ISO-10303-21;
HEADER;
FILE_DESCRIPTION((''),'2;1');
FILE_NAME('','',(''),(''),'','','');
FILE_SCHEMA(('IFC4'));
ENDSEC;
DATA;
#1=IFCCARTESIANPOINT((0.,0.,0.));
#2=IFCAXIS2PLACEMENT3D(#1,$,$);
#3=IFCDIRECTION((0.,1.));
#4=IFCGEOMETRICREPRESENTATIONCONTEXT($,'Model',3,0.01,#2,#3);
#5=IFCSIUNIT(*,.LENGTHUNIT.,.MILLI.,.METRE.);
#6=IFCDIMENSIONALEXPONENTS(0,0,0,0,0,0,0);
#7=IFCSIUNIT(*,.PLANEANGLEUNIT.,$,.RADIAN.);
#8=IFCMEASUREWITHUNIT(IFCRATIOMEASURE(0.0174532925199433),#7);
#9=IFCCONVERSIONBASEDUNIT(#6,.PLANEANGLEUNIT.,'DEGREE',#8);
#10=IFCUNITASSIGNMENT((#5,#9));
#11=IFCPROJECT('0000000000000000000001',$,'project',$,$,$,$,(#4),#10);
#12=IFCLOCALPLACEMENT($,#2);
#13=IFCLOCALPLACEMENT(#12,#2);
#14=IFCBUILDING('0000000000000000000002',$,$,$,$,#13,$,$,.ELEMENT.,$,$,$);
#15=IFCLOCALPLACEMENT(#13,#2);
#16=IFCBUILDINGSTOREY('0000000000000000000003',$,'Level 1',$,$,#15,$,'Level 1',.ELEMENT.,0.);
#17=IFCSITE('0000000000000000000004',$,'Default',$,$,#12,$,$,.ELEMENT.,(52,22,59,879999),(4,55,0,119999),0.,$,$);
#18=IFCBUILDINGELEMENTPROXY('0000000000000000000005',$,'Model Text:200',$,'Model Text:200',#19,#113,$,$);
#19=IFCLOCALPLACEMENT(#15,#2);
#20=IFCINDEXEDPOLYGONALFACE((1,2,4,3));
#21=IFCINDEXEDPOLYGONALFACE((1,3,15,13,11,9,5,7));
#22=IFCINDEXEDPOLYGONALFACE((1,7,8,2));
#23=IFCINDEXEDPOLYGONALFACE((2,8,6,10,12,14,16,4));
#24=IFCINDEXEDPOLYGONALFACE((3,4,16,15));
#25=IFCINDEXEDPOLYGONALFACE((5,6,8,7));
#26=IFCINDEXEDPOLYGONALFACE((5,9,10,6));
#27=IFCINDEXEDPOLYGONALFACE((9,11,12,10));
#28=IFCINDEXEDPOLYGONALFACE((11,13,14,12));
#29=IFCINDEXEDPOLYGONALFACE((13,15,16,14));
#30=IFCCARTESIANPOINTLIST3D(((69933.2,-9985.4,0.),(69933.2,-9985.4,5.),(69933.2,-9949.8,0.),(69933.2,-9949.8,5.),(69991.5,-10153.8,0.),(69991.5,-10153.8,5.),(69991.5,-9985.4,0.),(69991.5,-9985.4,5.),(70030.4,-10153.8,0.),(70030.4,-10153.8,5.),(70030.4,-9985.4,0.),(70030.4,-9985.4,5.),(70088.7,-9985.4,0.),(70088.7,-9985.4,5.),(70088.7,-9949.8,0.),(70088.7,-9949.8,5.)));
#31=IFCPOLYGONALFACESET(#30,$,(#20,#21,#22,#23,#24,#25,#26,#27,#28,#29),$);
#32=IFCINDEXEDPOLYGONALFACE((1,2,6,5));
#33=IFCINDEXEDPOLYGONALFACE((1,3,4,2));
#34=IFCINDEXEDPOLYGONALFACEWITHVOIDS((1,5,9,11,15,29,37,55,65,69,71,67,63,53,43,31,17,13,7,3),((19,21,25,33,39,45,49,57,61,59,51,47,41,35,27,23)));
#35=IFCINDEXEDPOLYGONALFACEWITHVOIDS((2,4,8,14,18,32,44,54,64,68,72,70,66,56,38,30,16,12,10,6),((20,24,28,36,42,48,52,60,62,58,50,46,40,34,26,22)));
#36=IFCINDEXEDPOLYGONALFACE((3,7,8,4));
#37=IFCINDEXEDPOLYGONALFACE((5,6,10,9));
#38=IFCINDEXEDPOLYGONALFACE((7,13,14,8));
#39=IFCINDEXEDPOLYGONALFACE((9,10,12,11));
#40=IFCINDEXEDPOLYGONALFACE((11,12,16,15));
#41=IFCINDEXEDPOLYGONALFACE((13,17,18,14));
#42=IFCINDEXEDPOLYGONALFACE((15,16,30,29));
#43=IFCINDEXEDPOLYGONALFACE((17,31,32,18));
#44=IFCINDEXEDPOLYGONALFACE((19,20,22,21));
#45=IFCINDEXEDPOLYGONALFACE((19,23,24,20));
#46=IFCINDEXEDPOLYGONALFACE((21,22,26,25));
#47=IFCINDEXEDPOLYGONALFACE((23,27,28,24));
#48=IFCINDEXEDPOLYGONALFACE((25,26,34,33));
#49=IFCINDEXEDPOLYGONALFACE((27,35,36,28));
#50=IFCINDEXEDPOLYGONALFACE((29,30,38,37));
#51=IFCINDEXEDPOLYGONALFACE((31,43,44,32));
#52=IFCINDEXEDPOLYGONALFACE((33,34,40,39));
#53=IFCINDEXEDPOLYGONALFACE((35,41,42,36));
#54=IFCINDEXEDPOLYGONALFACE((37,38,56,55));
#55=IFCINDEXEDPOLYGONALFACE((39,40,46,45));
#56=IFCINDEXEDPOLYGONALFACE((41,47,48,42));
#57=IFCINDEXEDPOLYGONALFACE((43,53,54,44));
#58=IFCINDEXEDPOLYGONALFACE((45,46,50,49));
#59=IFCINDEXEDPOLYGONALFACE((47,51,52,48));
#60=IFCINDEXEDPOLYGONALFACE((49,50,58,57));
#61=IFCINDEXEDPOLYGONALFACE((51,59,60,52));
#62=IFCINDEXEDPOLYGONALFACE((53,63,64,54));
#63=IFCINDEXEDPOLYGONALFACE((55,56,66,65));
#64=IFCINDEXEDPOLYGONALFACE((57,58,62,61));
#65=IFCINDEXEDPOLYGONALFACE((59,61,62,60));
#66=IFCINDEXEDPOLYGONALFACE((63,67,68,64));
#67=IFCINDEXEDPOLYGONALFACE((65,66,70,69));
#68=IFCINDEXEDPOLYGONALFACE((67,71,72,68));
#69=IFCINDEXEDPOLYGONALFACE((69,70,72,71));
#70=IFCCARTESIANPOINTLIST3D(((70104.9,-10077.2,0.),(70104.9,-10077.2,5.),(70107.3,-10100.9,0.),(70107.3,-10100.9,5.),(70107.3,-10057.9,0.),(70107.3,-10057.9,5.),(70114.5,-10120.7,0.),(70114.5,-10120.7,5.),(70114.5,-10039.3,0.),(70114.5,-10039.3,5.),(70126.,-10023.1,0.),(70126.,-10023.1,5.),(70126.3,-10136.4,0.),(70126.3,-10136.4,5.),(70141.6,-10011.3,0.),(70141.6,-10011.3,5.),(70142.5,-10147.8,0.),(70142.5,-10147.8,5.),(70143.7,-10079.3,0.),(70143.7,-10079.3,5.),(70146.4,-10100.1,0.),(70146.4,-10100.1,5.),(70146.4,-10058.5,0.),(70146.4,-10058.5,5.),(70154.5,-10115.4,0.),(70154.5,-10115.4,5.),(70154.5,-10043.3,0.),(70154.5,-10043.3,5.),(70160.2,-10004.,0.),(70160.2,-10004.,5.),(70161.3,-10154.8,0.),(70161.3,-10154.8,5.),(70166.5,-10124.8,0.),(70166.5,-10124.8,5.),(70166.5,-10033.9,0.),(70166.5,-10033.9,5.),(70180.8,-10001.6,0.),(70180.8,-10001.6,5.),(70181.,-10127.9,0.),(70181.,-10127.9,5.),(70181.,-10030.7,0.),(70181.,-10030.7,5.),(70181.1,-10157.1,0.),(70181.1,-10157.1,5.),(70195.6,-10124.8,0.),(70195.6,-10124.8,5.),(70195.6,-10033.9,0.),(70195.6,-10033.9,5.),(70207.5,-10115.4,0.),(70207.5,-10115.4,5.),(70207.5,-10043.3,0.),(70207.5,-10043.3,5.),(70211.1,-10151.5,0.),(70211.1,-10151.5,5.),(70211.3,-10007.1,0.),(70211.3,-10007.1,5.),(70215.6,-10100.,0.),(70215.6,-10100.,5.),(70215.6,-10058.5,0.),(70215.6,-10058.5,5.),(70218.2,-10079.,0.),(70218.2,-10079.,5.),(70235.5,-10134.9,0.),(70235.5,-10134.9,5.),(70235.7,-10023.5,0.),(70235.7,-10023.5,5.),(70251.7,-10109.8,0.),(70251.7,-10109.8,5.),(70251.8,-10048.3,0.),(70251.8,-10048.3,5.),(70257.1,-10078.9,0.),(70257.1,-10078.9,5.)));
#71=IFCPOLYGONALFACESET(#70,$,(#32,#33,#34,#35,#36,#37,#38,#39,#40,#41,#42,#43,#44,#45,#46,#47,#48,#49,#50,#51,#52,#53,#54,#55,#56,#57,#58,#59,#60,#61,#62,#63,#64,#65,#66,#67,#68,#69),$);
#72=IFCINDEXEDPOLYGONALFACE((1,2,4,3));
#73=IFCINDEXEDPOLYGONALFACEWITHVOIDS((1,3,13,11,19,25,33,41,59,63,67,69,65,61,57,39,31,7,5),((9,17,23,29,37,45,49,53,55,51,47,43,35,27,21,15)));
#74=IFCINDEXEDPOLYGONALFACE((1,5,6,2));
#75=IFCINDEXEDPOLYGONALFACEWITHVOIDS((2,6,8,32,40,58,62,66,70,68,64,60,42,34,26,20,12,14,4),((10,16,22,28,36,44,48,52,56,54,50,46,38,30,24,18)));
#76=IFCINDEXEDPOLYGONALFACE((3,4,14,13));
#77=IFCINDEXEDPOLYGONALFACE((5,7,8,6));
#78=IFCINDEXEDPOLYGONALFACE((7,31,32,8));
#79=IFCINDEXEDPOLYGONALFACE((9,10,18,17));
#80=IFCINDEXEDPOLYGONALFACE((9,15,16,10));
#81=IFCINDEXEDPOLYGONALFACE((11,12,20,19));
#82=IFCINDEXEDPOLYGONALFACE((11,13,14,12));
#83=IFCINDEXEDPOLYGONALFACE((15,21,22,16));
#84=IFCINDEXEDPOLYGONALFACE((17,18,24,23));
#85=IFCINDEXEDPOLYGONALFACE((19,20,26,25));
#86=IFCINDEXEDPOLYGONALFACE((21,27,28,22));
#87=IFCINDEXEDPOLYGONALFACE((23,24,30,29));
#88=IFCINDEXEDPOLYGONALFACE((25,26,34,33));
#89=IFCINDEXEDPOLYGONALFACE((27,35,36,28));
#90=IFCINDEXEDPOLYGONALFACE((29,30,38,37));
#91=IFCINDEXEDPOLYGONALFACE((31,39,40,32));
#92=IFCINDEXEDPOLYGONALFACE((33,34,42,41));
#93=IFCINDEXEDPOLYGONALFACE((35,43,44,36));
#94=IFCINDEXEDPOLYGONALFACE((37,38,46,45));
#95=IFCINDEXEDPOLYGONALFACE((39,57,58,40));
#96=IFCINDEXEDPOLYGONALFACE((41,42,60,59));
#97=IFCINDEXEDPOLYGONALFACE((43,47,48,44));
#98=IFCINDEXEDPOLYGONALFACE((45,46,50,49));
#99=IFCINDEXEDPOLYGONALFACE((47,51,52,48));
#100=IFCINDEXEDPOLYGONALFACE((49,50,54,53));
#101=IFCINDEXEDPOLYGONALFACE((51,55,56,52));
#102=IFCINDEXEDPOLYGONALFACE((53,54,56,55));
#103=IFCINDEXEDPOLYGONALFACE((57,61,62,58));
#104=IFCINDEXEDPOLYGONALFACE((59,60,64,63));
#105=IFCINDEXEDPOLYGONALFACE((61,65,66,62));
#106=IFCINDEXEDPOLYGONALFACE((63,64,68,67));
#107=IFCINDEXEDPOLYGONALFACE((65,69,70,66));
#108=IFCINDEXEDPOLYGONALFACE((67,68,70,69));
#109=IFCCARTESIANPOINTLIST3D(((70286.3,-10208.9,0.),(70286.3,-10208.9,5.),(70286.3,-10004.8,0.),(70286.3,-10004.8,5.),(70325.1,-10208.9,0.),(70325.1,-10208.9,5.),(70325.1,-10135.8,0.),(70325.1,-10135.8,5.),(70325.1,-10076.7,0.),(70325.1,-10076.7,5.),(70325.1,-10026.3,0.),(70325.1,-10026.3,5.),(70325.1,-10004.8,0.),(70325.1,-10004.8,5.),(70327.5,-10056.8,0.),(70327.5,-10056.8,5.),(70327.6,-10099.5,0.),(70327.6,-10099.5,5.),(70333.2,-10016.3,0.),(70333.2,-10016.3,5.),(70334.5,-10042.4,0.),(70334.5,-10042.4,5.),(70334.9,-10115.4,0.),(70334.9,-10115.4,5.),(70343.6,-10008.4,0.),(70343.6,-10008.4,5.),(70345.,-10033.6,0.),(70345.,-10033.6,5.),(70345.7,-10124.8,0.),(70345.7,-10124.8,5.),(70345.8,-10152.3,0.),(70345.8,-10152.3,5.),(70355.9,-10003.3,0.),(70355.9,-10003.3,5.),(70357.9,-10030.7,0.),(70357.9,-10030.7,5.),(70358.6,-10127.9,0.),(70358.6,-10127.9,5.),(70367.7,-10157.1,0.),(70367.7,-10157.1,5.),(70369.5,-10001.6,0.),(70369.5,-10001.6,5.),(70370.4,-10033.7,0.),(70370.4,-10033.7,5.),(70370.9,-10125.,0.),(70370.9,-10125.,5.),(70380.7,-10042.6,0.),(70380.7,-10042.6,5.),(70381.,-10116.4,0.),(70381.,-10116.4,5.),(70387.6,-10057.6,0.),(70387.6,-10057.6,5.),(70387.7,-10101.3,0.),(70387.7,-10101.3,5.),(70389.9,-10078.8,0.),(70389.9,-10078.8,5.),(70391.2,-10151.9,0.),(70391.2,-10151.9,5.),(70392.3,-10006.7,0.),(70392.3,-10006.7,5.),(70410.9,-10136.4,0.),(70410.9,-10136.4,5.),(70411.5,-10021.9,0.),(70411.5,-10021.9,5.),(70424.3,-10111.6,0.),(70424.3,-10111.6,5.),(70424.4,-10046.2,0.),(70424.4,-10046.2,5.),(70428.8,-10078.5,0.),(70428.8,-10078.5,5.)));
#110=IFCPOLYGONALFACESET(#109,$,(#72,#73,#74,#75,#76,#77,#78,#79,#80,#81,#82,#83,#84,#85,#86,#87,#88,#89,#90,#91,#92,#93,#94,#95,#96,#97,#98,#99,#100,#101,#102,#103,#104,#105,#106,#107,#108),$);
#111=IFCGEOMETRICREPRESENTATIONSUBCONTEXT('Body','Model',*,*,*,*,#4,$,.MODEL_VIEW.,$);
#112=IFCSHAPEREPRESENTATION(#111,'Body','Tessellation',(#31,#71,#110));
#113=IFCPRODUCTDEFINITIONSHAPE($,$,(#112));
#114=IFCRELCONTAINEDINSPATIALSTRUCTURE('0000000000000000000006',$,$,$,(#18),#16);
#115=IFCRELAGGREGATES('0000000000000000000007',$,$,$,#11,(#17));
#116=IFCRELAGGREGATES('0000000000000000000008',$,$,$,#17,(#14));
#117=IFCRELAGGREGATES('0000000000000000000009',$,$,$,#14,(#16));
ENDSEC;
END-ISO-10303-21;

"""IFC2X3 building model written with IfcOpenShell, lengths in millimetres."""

from ifc_helpers import new_model, entity, si_unit, converted_unit, direction, frame, origin, place, context, subcontext, project, spatial, polyline, outline, extrude, element, save


model = new_model("IFC2X3")

# Units and contexts
model_context = context("Model", 3, precision=0.01, world=origin(), true_north=direction((0.0, 1.0)))
body_context = subcontext(model_context, "Body", "Model", "MODEL_VIEW")
ifc_project = project(units=[si_unit("LENGTHUNIT", "METRE", prefix="MILLI"), converted_unit("PLANEANGLEUNIT", "DEGREE", entity("IfcRatioMeasure", 0.0174532925199433), si_unit("PLANEANGLEUNIT", "RADIAN"), dimensions=[0, 0, 0, 0, 0, 0, 0])], contexts=[model_context])

# Site, building, storey
site_placement = place(None, origin())
site = spatial("IfcSite", under=ifc_project, at=site_placement, Name="Default", CompositionType="ELEMENT", RefLatitude=(52, 22, 59, 879999), RefLongitude=(4, 55, 0, 119999), RefElevation=0.0)
building_placement = place(site_placement, origin())
building = spatial("IfcBuilding", under=site, at=building_placement, CompositionType="ELEMENT")
storey_placement = place(building_placement, origin())
storey = spatial("IfcBuildingStorey", under=building, at=storey_placement, Name="Level 1", LongName="Level 1", CompositionType="ELEMENT", Elevation=0.0)

# Building element proxy
proxy_1_placement = place(building_placement, origin())
element("IfcBuildingElementProxy", 1, at=proxy_1_placement, inside=storey, Name="Model Text:200", ObjectType="Model Text:200", context=body_context, shape_type="SweptSolid", body=[
    extrude(outline(polyline([(-19.4, -135.2), (19.4, -135.2), (19.4, 33.2), (77.7, 33.2), (77.7, 68.8), (-77.7, 68.8), (-77.7, 33.2), (-19.4, 33.2), (-19.4, -135.2)])), frame((70010.9, -10018.6, 0.0)), (0.0, 0.0, 1.0), 5.0),
    extrude(outline(polyline([(-8.8, -65.7), (15.1, -65.7), (35.5, -60.5), (52.3, -50.4), (65.3, -35.4), (74.1, -17.3), (78.4, 2.1), (75.9, 32.5), (61.8, 58.5), (38.4, 77.1), (8.3, 85.6), (-22.7, 83.3), (-49.0, 69.9), (-67.8, 47.3), (-76.3, 17.5), (-76.0, -3.3), (-70.7, -22.5), (-60.5, -39.2), (-45.5, -52.3), (-27.7, -61.4), (-8.8, -65.7)]), holes=[polyline([(-2.7, -27.2), (-23.1, -22.5), (-37.5, -12.9), (-45.7, 0.0), (-47.3, 14.8), (-42.7, 28.9), (-32.2, 39.9), (-16.3, 46.3), (4.5, 46.9), (25.1, 42.1), (39.6, 32.6), (47.7, 19.7), (49.4, 5.0), (44.8, -9.2), (34.2, -20.2), (18.2, -26.7), (-2.7, -27.2)])]), frame((70171.1, -10079.3, 0.0), z_axis=(0.0, 0.0, 1.0), x_axis=(0.100608, -0.994926, 0.0)), (0.0, 0.0, 1.0), 5.0),
    extrude(outline(polyline([(-73.1, -75.4), (130.9, -75.4), (130.9, -36.6), (57.8, -36.6), (74.3, -15.9), (79.1, 6.0), (73.9, 29.5), (58.4, 49.2), (33.6, 62.6), (0.5, 67.1), (-31.8, 62.8), (-56.1, 49.8), (-71.3, 30.7), (-76.4, 7.8), (-74.7, -5.8), (-69.6, -18.1), (-61.7, -28.5), (-51.7, -36.6), (-73.1, -36.6), (-73.1, -75.4)]), holes=[polyline([(-1.2, -36.6), (-21.2, -34.2), (-35.6, -27.2), (-44.3, -16.7), (-47.2, -3.8), (-44.3, 8.7), (-35.4, 19.0), (-20.4, 25.9), (0.8, 28.2), (23.3, 26.0), (38.5, 19.3), (47.1, 9.2), (49.9, -3.1), (46.8, -16.0), (37.4, -26.8), (21.5, -34.1), (-1.2, -36.6)])]), frame((70361.7, -10078.0, 0.0), z_axis=(0.0, 0.0, 1.0), x_axis=(0.0, -1.0, 0.0)), (0.0, 0.0, 1.0), 5.0),
])

save(model, "model.ifc")
